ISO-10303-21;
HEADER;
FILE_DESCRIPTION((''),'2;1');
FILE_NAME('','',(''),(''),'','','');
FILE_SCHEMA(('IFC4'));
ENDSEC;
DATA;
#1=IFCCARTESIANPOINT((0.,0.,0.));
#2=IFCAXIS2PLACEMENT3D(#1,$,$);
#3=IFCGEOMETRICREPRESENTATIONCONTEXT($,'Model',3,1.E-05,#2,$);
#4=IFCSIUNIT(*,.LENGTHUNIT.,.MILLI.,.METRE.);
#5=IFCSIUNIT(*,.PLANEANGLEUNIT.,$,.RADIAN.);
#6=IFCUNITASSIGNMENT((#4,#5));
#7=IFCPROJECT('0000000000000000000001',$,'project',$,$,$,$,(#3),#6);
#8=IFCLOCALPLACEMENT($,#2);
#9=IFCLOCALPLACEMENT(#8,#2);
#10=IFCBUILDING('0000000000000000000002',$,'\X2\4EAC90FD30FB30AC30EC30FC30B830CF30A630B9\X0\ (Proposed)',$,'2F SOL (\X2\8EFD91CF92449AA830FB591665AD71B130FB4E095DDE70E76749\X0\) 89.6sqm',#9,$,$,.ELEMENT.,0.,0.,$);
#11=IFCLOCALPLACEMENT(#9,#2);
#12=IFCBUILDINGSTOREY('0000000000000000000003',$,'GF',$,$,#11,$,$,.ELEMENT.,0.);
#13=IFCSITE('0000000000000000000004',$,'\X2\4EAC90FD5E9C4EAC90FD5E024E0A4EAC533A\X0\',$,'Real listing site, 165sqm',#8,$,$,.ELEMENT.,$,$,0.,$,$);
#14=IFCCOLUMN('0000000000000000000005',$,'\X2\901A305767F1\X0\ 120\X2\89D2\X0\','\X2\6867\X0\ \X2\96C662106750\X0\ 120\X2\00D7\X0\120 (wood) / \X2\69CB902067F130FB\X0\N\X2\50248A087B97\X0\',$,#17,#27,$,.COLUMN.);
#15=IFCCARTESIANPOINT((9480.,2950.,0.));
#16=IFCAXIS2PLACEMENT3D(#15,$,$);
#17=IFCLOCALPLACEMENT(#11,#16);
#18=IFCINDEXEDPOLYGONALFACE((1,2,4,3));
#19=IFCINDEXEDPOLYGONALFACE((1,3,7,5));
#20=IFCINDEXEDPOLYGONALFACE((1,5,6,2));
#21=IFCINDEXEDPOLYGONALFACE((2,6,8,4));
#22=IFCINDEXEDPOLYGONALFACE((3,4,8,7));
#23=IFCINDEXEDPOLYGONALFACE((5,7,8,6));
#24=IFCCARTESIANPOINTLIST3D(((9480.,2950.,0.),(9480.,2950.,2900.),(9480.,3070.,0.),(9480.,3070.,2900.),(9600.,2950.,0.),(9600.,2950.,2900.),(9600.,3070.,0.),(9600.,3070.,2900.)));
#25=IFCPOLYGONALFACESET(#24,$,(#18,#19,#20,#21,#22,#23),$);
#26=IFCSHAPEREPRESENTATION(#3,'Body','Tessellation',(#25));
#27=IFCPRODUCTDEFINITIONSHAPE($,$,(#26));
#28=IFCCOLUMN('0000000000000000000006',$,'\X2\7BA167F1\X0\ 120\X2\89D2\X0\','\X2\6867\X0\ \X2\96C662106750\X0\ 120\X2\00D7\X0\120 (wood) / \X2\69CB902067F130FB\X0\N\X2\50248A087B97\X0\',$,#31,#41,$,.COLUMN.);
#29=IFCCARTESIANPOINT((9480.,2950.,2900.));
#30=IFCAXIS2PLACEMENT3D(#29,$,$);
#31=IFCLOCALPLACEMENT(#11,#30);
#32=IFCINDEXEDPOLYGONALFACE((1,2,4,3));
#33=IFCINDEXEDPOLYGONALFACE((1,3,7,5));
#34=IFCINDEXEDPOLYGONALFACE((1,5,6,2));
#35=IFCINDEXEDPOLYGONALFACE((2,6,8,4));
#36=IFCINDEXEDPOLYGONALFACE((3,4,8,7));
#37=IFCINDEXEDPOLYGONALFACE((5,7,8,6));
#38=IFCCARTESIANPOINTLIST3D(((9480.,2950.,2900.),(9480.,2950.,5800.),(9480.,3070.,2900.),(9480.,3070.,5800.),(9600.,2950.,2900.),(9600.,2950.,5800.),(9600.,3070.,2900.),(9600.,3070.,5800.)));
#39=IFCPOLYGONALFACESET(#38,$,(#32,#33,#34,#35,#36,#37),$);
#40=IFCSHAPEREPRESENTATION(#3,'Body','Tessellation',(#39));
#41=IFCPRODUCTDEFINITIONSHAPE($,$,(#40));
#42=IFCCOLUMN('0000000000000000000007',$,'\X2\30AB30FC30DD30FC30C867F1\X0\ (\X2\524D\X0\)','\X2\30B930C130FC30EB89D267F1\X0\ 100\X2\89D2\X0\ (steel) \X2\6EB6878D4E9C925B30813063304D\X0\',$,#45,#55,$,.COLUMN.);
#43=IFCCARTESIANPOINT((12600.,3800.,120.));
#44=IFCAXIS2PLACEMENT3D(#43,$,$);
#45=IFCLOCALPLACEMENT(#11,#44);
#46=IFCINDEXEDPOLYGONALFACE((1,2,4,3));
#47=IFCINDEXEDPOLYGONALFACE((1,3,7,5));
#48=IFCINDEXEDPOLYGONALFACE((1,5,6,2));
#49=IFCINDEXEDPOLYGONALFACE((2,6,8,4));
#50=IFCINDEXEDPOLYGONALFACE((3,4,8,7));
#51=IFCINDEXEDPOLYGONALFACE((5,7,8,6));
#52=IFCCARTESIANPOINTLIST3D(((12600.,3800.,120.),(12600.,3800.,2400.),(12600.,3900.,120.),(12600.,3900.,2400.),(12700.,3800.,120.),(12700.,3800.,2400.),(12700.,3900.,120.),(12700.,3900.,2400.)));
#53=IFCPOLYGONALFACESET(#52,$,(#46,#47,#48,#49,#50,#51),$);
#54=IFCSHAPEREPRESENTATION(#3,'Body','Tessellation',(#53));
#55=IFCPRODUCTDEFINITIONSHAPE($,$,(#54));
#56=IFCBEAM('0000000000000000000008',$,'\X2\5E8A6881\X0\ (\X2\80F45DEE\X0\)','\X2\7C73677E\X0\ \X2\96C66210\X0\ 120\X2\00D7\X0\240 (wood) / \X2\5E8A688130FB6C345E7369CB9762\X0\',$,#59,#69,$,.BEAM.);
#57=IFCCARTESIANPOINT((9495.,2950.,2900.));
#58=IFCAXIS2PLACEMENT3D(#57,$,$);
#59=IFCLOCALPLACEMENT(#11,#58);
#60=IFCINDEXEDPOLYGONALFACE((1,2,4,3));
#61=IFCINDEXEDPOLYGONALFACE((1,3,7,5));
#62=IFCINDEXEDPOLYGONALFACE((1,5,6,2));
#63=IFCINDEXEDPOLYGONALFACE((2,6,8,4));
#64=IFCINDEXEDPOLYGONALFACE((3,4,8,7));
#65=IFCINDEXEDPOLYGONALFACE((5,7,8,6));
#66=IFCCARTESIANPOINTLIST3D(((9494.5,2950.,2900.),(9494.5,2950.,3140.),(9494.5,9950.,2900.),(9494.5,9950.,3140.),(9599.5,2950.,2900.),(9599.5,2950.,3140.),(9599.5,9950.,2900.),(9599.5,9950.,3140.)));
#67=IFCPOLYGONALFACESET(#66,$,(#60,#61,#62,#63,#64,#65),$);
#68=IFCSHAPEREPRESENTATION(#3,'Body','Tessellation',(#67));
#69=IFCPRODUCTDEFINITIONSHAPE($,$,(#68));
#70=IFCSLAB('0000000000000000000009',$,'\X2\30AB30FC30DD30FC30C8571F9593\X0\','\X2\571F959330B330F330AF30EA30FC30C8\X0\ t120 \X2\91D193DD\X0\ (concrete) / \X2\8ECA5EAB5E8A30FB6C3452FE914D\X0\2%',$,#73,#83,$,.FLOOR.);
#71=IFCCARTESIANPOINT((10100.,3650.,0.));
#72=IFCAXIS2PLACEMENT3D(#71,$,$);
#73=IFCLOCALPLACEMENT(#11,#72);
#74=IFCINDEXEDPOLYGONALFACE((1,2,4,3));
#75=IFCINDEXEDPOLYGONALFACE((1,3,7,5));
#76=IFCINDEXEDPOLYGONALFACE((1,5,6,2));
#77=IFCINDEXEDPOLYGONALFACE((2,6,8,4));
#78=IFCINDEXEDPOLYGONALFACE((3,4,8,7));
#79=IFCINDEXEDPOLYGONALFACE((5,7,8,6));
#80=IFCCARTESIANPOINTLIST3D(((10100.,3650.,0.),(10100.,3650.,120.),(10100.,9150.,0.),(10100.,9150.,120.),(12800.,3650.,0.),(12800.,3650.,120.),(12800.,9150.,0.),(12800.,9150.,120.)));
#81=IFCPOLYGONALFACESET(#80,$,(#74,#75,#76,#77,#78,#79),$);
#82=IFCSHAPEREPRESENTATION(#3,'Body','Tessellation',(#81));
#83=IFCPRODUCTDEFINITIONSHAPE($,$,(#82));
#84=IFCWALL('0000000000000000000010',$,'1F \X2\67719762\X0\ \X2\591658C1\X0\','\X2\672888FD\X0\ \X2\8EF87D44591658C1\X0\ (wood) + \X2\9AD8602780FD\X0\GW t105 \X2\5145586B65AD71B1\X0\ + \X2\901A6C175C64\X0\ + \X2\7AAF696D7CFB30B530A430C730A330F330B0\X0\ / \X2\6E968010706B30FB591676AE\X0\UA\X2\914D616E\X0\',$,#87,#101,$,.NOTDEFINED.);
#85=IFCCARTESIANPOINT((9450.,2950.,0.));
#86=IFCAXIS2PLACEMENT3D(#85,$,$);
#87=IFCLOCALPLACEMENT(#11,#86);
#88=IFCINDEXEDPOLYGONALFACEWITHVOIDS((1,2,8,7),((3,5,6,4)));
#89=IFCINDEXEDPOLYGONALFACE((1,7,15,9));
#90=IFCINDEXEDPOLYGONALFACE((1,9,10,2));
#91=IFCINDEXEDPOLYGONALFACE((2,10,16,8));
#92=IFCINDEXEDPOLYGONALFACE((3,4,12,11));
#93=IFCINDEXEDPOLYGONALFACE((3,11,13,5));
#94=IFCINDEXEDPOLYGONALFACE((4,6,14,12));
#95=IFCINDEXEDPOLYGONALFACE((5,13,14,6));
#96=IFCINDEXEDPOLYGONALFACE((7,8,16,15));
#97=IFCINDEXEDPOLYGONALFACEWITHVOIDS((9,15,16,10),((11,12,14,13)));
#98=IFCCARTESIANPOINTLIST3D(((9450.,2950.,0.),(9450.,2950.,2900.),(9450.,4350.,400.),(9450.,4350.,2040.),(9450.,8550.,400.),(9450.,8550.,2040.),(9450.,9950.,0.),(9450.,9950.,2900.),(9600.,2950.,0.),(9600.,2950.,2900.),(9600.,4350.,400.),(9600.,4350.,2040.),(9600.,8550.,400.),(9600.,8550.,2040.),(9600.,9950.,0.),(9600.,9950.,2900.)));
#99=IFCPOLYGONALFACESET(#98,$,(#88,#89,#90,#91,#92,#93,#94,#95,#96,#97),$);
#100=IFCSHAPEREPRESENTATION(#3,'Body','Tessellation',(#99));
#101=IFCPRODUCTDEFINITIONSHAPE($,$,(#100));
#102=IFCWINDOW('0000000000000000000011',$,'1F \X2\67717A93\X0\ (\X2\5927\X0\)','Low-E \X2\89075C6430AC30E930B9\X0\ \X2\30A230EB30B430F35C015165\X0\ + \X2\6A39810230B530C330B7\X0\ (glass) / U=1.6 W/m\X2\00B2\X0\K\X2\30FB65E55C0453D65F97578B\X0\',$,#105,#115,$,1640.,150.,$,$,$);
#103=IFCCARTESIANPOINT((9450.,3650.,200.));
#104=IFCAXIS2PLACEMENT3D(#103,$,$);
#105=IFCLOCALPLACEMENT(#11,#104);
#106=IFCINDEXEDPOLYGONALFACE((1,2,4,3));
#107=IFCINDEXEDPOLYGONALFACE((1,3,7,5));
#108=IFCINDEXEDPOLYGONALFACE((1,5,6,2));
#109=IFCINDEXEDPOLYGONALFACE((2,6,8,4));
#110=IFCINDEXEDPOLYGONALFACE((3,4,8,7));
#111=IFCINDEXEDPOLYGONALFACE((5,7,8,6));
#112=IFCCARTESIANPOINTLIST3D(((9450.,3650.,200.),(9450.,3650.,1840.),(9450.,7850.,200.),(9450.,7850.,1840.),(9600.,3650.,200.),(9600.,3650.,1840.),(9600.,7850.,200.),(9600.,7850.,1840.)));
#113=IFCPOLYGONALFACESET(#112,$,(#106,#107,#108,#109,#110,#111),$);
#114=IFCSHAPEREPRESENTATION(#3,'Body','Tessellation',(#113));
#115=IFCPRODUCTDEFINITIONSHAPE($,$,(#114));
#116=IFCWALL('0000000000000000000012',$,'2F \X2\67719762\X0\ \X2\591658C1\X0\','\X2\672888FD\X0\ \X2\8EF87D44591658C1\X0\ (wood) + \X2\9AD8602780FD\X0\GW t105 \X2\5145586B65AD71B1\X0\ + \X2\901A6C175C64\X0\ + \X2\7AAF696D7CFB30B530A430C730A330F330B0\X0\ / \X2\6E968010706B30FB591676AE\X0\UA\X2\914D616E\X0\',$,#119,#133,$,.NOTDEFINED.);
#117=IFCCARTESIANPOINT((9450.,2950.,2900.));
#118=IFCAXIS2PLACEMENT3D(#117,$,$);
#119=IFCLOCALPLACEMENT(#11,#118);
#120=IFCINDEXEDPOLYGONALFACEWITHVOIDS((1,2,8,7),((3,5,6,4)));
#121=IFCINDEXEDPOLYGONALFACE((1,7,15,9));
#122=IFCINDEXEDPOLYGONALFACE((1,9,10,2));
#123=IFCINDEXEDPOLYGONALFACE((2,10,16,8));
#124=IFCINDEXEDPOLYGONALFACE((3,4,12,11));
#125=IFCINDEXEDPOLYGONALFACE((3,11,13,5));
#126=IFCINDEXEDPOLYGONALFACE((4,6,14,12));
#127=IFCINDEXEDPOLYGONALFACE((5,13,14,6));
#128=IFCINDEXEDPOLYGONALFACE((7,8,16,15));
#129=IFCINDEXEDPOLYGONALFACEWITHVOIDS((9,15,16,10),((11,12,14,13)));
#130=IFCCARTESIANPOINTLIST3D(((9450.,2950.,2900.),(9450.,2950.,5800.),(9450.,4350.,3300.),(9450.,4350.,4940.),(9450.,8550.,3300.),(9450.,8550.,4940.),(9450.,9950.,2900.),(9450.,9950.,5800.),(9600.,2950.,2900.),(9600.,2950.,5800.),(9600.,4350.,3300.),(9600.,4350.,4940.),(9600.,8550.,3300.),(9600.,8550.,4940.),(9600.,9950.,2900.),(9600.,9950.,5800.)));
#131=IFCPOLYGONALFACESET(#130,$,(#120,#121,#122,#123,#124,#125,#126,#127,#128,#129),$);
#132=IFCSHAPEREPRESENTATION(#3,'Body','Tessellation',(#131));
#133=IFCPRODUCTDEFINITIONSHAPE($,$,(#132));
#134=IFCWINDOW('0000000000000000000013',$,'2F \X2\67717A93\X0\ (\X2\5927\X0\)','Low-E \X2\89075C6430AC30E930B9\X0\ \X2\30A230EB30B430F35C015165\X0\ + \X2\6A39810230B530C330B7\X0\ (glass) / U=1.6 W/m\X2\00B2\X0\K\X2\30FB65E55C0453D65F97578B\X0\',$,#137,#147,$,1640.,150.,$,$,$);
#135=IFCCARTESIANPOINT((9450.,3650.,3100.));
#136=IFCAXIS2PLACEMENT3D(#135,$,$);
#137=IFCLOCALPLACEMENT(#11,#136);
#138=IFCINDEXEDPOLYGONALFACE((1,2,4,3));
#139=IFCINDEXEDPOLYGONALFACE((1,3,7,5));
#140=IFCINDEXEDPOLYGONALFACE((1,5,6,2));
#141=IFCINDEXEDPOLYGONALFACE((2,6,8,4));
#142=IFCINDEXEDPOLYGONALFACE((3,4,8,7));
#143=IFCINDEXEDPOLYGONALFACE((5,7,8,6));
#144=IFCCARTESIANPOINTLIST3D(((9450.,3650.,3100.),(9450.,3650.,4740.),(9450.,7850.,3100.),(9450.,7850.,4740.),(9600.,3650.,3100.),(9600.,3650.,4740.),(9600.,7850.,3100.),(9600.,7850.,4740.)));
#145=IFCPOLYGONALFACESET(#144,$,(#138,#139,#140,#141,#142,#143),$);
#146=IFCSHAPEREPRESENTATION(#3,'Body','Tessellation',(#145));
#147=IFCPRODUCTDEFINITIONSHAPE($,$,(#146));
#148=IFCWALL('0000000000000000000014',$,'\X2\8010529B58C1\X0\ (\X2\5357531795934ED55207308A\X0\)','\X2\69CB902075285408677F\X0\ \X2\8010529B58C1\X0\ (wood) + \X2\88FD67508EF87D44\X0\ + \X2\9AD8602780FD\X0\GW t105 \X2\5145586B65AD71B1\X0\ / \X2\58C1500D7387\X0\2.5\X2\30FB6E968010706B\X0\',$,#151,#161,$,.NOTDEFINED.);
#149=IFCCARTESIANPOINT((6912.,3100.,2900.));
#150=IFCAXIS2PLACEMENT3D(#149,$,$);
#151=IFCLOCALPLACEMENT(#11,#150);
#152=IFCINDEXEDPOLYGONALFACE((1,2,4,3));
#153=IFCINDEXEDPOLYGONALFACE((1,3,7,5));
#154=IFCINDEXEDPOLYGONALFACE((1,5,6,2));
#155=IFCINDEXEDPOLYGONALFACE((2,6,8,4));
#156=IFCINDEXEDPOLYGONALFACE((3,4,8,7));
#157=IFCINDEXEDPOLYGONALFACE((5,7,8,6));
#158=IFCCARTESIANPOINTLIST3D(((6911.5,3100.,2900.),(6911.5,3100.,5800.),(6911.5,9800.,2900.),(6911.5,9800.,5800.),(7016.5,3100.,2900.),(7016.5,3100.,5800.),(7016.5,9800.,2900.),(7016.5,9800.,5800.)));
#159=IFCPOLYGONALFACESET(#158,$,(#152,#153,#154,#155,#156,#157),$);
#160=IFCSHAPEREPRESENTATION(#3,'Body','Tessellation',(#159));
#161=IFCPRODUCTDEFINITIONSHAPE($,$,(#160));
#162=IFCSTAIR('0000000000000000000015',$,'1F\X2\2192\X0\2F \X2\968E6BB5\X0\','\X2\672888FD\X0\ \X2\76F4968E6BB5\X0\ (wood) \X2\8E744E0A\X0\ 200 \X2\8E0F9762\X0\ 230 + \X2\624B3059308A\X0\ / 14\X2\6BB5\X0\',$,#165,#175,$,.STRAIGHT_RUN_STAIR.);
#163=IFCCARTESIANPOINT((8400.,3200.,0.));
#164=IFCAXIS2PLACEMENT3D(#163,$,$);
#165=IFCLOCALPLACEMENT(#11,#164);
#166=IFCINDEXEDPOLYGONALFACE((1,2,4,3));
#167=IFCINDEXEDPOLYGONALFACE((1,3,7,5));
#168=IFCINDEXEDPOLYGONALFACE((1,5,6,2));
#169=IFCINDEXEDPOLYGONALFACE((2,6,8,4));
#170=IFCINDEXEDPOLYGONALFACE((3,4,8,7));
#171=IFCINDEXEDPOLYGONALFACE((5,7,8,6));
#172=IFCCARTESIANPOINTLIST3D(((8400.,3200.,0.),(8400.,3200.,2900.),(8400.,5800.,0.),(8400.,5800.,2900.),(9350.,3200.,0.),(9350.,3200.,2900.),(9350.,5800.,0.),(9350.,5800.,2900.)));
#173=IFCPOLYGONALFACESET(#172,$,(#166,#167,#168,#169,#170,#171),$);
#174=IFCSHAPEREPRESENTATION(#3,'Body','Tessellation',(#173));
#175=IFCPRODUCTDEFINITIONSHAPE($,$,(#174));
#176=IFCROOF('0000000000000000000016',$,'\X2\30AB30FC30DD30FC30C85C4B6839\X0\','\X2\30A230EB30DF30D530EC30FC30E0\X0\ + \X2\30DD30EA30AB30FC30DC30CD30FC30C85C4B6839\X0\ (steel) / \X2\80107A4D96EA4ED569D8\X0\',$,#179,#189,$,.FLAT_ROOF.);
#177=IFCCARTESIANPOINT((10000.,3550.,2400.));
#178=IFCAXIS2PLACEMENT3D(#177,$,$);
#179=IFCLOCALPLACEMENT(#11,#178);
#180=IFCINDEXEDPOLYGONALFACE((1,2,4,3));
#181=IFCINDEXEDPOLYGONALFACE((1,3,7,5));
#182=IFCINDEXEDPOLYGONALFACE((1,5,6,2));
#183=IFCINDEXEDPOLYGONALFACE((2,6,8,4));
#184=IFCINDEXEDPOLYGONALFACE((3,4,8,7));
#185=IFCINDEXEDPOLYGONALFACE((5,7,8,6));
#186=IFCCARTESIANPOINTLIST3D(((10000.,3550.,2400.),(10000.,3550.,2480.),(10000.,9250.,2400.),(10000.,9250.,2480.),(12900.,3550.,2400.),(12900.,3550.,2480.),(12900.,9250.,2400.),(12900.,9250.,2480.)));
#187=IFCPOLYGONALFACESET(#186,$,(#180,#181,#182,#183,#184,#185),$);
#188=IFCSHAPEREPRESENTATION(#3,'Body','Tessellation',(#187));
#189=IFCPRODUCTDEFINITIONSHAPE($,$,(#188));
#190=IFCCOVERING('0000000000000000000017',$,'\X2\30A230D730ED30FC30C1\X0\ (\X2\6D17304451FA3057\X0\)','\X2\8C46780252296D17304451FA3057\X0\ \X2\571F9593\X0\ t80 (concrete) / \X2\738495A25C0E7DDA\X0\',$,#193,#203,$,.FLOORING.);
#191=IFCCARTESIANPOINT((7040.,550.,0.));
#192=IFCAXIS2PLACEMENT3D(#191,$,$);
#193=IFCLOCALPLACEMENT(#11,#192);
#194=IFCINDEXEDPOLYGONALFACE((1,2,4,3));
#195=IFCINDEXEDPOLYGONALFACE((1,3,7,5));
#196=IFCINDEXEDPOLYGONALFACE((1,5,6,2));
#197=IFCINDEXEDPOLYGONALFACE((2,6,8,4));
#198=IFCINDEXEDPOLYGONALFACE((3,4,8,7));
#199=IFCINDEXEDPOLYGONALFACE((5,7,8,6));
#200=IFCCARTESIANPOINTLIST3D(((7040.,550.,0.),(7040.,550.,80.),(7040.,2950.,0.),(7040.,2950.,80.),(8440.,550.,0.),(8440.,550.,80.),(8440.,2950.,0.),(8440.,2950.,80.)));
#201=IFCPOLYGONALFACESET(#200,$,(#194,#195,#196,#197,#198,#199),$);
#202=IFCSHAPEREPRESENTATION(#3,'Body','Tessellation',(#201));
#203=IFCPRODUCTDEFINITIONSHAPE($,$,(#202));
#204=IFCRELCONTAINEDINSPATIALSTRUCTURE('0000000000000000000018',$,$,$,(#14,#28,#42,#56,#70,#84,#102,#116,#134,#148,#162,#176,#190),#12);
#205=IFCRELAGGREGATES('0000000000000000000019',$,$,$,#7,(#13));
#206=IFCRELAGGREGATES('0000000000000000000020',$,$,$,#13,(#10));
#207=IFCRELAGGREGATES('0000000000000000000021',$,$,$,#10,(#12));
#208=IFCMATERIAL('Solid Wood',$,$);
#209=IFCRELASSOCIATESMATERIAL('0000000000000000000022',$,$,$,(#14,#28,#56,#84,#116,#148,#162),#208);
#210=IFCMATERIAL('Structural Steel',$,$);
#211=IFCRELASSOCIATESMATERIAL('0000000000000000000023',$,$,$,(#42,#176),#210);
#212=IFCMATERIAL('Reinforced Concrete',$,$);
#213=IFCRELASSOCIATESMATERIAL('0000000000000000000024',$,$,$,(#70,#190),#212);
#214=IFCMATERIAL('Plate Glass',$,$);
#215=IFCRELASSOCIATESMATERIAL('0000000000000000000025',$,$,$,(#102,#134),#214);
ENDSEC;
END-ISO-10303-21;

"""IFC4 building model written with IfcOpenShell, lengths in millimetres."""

from ifc_helpers import new_model, si_unit, frame, frame_2d, origin, place, context, project, spatial, rectangle, extrude, material, element, fill, save


model = new_model("IFC4")

# Units and contexts
model_context = context("Model", 3, precision=1e-05, world=origin())
ifc_project = project(units=[si_unit("LENGTHUNIT", "METRE", prefix="MILLI"), si_unit("PLANEANGLEUNIT", "RADIAN")], contexts=[model_context])

# Site, building, storey
site_placement = place(None, origin())
site = spatial("IfcSite", under=ifc_project, at=site_placement, Name="京都府京都市上京区", ObjectType="Real listing site, 165sqm", CompositionType="ELEMENT", RefElevation=0.0)
building_placement = place(site_placement, origin())
building = spatial("IfcBuilding", under=site, at=building_placement, Name="京都・ガレージハウス (Proposed)", ObjectType="2F SOL (軽量鉄骨・外断熱・三州烧杉) 89.6sqm", CompositionType="ELEMENT", ElevationOfRefHeight=0.0, ElevationOfTerrain=0.0)
storey_placement = place(building_placement, origin())
storey = spatial("IfcBuildingStorey", under=building, at=storey_placement, Name="GF", CompositionType="ELEMENT", Elevation=0.0)

# Columns
ifc_material_1 = material(Name="Solid Wood")
column_1_placement = place(storey_placement, frame((9480.0, 2950.0, 0.0)))
element("IfcColumn", 1, at=column_1_placement, inside=storey, material=ifc_material_1, Name="通し柱 120角", Description="桧 集成材 120×120 (wood) / 構造柱・N値計算", PredefinedType="COLUMN", context=model_context, shape_type="SweptSolid", body=[
    extrude(rectangle(XDim=120.0, YDim=120.0, at=frame_2d((60.0, 60.0))), frame((9480.0, 2950.0, 0.0)), (0.0, 0.0, 1.0), 2900.0),
])
column_2_placement = place(storey_placement, frame((9480.0, 2950.0, 2900.0)))
element("IfcColumn", 2, at=column_2_placement, inside=storey, material=ifc_material_1, Name="管柱 120角", Description="桧 集成材 120×120 (wood) / 構造柱・N値計算", PredefinedType="COLUMN", context=model_context, shape_type="SweptSolid", body=[
    extrude(rectangle(XDim=120.0, YDim=120.0, at=frame_2d((60.0, 60.0))), frame((9480.0, 2950.0, 2900.0)), (0.0, 0.0, 1.0), 2900.0),
])
ifc_material_2 = material(Name="Structural Steel")
column_3_placement = place(storey_placement, frame((12600.0, 3800.0, 120.0)))
element("IfcColumn", 3, at=column_3_placement, inside=storey, material=ifc_material_2, Name="カーポート柱 (前)", Description="スチール角柱 100角 (steel) 溶融亜鉛めっき", PredefinedType="COLUMN", context=model_context, shape_type="SweptSolid", body=[
    extrude(rectangle(XDim=100.0, YDim=100.0, at=frame_2d((50.0, 50.0))), frame((12600.0, 3800.0, 120.0)), (0.0, 0.0, 1.0), 2280.0),
])

# Beam
beam_1_placement = place(storey_placement, frame((9495.0, 2950.0, 2900.0)))
element("IfcBeam", 4, at=beam_1_placement, inside=storey, material=ifc_material_1, Name="床梁 (胴差)", Description="米松 集成 120×240 (wood) / 床梁・水平構面", PredefinedType="BEAM", context=model_context, shape_type="SweptSolid", body=[
    extrude(rectangle(XDim=105.0, YDim=7000.0, at=frame_2d((52.0, 3500.0))), frame((9495.0, 2950.0, 2900.0)), (0.0, 0.0, 1.0), 240.0),
])

# Slab
ifc_material_3 = material(Name="Reinforced Concrete")
slab_placement = place(storey_placement, frame((10100.0, 3650.0, 0.0)))
element("IfcSlab", 5, at=slab_placement, inside=storey, material=ifc_material_3, Name="カーポート土間", Description="土間コンクリート t120 金鏝 (concrete) / 車庫床・水勾配2%", PredefinedType="FLOOR", context=model_context, shape_type="SweptSolid", body=[
    extrude(rectangle(XDim=2700.0, YDim=5500.0, at=frame_2d((1350.0, 2750.0))), frame((10100.0, 3650.0, 0.0)), (0.0, 0.0, 1.0), 120.0),
])

# Wall, opening, window
wall_1_placement = place(storey_placement, frame((9450.0, 2950.0, 0.0)))
wall_1 = element("IfcWall", 6, at=wall_1_placement, inside=storey, material=ifc_material_1, Name="1F 東面 外壁", Description="木製 軸組外壁 (wood) + 高性能GW t105 充填断熱 + 通気層 + 窯業系サイディング / 準耐火・外皮UA配慮", PredefinedType="NOTDEFINED", context=model_context, shape_type="SweptSolid", body=[
    extrude(rectangle(XDim=150.0, YDim=7000.0, at=frame_2d((75.0, 3500.0))), frame((9450.0, 2950.0, 0.0)), (0.0, 0.0, 1.0), 2900.0),
])
opening_1_placement = place(storey_placement, frame((9450.0, 3650.0, 200.0)))
opening_1 = element("IfcOpeningElement", 7, at=opening_1_placement, cuts=wall_1, PredefinedType="NOTDEFINED", context=model_context, shape_type="SweptSolid", body=[
    extrude(rectangle(XDim=150.0, YDim=4200.0, at=frame_2d((75.0, 2100.0))), frame((9450.0, 3650.0, 200.0)), (0.0, 0.0, 1.0), 1640.0),
])
ifc_material_4 = material(Name="Plate Glass")
window_1_placement = place(storey_placement, frame((9450.0, 3650.0, 200.0)))
window_1 = element("IfcWindow", 8, at=window_1_placement, inside=storey, material=ifc_material_4, Name="1F 東窓 (大)", Description="Low-E 複層ガラス アルゴン封入 + 樹脂サッシ (glass) / U=1.6 W/m²K・日射取得型", OverallHeight=1640.0, OverallWidth=150.0, context=model_context, shape_type="SweptSolid", body=[
    extrude(rectangle(XDim=150.0, YDim=4200.0, at=frame_2d((75.0, 2100.0))), frame((9450.0, 3650.0, 200.0)), (0.0, 0.0, 1.0), 1640.0),
])
fill(opening_1, window_1)

# Wall, opening, window
wall_2_placement = place(storey_placement, frame((9450.0, 2950.0, 2900.0)))
wall_2 = element("IfcWall", 9, at=wall_2_placement, inside=storey, material=ifc_material_1, Name="2F 東面 外壁", Description="木製 軸組外壁 (wood) + 高性能GW t105 充填断熱 + 通気層 + 窯業系サイディング / 準耐火・外皮UA配慮", PredefinedType="NOTDEFINED", context=model_context, shape_type="SweptSolid", body=[
    extrude(rectangle(XDim=150.0, YDim=7000.0, at=frame_2d((75.0, 3500.0))), frame((9450.0, 2950.0, 2900.0)), (0.0, 0.0, 1.0), 2900.0),
])
opening_2_placement = place(storey_placement, frame((9450.0, 3650.0, 3100.0)))
opening_2 = element("IfcOpeningElement", 10, at=opening_2_placement, cuts=wall_2, PredefinedType="NOTDEFINED", context=model_context, shape_type="SweptSolid", body=[
    extrude(rectangle(XDim=150.0, YDim=4200.0, at=frame_2d((75.0, 2100.0))), frame((9450.0, 3650.0, 3100.0)), (0.0, 0.0, 1.0), 1640.0),
])
window_2_placement = place(storey_placement, frame((9450.0, 3650.0, 3100.0)))
window_2 = element("IfcWindow", 11, at=window_2_placement, inside=storey, material=ifc_material_4, Name="2F 東窓 (大)", Description="Low-E 複層ガラス アルゴン封入 + 樹脂サッシ (glass) / U=1.6 W/m²K・日射取得型", OverallHeight=1640.0, OverallWidth=150.0, context=model_context, shape_type="SweptSolid", body=[
    extrude(rectangle(XDim=150.0, YDim=4200.0, at=frame_2d((75.0, 2100.0))), frame((9450.0, 3650.0, 3100.0)), (0.0, 0.0, 1.0), 1640.0),
])
fill(opening_2, window_2)

# Wall
wall_3_placement = place(storey_placement, frame((6912.0, 3100.0, 2900.0)))
element("IfcWall", 12, at=wall_3_placement, inside=storey, material=ifc_material_1, Name="耐力壁 (南北間仕切り)", Description="構造用合板 耐力壁 (wood) + 製材軸組 + 高性能GW t105 充填断熱 / 壁倍率2.5・準耐火", PredefinedType="NOTDEFINED", context=model_context, shape_type="SweptSolid", body=[
    extrude(rectangle(XDim=105.0, YDim=6700.0, at=frame_2d((52.0, 3350.0))), frame((6912.0, 3100.0, 2900.0)), (0.0, 0.0, 1.0), 2900.0),
])

# Stair
stair_placement = place(storey_placement, frame((8400.0, 3200.0, 0.0)))
element("IfcStair", 13, at=stair_placement, inside=storey, material=ifc_material_1, Name="1F→2F 階段", Description="木製 直階段 (wood) 蹴上 200 踏面 230 + 手すり / 14段", PredefinedType="STRAIGHT_RUN_STAIR", context=model_context, shape_type="SweptSolid", body=[
    extrude(rectangle(XDim=950.0, YDim=2600.0, at=frame_2d((475.0, 1300.0))), frame((8400.0, 3200.0, 0.0)), (0.0, 0.0, 1.0), 2900.0),
])

# Roof
roof_placement = place(storey_placement, frame((10000.0, 3550.0, 2400.0)))
element("IfcRoof", 14, at=roof_placement, inside=storey, material=ifc_material_2, Name="カーポート屋根", Description="アルミフレーム + ポリカーボネート屋根 (steel) / 耐積雪仕様", PredefinedType="FLAT_ROOF", context=model_context, shape_type="SweptSolid", body=[
    extrude(rectangle(XDim=2900.0, YDim=5700.0, at=frame_2d((1450.0, 2850.0))), frame((10000.0, 3550.0, 2400.0)), (0.0, 0.0, 1.0), 80.0),
])

# Covering
covering_placement = place(storey_placement, frame((7040.0, 550.0, 0.0)))
element("IfcCovering", 15, at=covering_placement, inside=storey, material=ifc_material_3, Name="アプローチ (洗い出し)", Description="豆砂利洗い出し 土間 t80 (concrete) / 玄関導線", PredefinedType="FLOORING", context=model_context, shape_type="SweptSolid", body=[
    extrude(rectangle(XDim=1400.0, YDim=2400.0, at=frame_2d((700.0, 1200.0))), frame((7040.0, 550.0, 0.0)), (0.0, 0.0, 1.0), 80.0),
])

save(model, "model.ifc")
